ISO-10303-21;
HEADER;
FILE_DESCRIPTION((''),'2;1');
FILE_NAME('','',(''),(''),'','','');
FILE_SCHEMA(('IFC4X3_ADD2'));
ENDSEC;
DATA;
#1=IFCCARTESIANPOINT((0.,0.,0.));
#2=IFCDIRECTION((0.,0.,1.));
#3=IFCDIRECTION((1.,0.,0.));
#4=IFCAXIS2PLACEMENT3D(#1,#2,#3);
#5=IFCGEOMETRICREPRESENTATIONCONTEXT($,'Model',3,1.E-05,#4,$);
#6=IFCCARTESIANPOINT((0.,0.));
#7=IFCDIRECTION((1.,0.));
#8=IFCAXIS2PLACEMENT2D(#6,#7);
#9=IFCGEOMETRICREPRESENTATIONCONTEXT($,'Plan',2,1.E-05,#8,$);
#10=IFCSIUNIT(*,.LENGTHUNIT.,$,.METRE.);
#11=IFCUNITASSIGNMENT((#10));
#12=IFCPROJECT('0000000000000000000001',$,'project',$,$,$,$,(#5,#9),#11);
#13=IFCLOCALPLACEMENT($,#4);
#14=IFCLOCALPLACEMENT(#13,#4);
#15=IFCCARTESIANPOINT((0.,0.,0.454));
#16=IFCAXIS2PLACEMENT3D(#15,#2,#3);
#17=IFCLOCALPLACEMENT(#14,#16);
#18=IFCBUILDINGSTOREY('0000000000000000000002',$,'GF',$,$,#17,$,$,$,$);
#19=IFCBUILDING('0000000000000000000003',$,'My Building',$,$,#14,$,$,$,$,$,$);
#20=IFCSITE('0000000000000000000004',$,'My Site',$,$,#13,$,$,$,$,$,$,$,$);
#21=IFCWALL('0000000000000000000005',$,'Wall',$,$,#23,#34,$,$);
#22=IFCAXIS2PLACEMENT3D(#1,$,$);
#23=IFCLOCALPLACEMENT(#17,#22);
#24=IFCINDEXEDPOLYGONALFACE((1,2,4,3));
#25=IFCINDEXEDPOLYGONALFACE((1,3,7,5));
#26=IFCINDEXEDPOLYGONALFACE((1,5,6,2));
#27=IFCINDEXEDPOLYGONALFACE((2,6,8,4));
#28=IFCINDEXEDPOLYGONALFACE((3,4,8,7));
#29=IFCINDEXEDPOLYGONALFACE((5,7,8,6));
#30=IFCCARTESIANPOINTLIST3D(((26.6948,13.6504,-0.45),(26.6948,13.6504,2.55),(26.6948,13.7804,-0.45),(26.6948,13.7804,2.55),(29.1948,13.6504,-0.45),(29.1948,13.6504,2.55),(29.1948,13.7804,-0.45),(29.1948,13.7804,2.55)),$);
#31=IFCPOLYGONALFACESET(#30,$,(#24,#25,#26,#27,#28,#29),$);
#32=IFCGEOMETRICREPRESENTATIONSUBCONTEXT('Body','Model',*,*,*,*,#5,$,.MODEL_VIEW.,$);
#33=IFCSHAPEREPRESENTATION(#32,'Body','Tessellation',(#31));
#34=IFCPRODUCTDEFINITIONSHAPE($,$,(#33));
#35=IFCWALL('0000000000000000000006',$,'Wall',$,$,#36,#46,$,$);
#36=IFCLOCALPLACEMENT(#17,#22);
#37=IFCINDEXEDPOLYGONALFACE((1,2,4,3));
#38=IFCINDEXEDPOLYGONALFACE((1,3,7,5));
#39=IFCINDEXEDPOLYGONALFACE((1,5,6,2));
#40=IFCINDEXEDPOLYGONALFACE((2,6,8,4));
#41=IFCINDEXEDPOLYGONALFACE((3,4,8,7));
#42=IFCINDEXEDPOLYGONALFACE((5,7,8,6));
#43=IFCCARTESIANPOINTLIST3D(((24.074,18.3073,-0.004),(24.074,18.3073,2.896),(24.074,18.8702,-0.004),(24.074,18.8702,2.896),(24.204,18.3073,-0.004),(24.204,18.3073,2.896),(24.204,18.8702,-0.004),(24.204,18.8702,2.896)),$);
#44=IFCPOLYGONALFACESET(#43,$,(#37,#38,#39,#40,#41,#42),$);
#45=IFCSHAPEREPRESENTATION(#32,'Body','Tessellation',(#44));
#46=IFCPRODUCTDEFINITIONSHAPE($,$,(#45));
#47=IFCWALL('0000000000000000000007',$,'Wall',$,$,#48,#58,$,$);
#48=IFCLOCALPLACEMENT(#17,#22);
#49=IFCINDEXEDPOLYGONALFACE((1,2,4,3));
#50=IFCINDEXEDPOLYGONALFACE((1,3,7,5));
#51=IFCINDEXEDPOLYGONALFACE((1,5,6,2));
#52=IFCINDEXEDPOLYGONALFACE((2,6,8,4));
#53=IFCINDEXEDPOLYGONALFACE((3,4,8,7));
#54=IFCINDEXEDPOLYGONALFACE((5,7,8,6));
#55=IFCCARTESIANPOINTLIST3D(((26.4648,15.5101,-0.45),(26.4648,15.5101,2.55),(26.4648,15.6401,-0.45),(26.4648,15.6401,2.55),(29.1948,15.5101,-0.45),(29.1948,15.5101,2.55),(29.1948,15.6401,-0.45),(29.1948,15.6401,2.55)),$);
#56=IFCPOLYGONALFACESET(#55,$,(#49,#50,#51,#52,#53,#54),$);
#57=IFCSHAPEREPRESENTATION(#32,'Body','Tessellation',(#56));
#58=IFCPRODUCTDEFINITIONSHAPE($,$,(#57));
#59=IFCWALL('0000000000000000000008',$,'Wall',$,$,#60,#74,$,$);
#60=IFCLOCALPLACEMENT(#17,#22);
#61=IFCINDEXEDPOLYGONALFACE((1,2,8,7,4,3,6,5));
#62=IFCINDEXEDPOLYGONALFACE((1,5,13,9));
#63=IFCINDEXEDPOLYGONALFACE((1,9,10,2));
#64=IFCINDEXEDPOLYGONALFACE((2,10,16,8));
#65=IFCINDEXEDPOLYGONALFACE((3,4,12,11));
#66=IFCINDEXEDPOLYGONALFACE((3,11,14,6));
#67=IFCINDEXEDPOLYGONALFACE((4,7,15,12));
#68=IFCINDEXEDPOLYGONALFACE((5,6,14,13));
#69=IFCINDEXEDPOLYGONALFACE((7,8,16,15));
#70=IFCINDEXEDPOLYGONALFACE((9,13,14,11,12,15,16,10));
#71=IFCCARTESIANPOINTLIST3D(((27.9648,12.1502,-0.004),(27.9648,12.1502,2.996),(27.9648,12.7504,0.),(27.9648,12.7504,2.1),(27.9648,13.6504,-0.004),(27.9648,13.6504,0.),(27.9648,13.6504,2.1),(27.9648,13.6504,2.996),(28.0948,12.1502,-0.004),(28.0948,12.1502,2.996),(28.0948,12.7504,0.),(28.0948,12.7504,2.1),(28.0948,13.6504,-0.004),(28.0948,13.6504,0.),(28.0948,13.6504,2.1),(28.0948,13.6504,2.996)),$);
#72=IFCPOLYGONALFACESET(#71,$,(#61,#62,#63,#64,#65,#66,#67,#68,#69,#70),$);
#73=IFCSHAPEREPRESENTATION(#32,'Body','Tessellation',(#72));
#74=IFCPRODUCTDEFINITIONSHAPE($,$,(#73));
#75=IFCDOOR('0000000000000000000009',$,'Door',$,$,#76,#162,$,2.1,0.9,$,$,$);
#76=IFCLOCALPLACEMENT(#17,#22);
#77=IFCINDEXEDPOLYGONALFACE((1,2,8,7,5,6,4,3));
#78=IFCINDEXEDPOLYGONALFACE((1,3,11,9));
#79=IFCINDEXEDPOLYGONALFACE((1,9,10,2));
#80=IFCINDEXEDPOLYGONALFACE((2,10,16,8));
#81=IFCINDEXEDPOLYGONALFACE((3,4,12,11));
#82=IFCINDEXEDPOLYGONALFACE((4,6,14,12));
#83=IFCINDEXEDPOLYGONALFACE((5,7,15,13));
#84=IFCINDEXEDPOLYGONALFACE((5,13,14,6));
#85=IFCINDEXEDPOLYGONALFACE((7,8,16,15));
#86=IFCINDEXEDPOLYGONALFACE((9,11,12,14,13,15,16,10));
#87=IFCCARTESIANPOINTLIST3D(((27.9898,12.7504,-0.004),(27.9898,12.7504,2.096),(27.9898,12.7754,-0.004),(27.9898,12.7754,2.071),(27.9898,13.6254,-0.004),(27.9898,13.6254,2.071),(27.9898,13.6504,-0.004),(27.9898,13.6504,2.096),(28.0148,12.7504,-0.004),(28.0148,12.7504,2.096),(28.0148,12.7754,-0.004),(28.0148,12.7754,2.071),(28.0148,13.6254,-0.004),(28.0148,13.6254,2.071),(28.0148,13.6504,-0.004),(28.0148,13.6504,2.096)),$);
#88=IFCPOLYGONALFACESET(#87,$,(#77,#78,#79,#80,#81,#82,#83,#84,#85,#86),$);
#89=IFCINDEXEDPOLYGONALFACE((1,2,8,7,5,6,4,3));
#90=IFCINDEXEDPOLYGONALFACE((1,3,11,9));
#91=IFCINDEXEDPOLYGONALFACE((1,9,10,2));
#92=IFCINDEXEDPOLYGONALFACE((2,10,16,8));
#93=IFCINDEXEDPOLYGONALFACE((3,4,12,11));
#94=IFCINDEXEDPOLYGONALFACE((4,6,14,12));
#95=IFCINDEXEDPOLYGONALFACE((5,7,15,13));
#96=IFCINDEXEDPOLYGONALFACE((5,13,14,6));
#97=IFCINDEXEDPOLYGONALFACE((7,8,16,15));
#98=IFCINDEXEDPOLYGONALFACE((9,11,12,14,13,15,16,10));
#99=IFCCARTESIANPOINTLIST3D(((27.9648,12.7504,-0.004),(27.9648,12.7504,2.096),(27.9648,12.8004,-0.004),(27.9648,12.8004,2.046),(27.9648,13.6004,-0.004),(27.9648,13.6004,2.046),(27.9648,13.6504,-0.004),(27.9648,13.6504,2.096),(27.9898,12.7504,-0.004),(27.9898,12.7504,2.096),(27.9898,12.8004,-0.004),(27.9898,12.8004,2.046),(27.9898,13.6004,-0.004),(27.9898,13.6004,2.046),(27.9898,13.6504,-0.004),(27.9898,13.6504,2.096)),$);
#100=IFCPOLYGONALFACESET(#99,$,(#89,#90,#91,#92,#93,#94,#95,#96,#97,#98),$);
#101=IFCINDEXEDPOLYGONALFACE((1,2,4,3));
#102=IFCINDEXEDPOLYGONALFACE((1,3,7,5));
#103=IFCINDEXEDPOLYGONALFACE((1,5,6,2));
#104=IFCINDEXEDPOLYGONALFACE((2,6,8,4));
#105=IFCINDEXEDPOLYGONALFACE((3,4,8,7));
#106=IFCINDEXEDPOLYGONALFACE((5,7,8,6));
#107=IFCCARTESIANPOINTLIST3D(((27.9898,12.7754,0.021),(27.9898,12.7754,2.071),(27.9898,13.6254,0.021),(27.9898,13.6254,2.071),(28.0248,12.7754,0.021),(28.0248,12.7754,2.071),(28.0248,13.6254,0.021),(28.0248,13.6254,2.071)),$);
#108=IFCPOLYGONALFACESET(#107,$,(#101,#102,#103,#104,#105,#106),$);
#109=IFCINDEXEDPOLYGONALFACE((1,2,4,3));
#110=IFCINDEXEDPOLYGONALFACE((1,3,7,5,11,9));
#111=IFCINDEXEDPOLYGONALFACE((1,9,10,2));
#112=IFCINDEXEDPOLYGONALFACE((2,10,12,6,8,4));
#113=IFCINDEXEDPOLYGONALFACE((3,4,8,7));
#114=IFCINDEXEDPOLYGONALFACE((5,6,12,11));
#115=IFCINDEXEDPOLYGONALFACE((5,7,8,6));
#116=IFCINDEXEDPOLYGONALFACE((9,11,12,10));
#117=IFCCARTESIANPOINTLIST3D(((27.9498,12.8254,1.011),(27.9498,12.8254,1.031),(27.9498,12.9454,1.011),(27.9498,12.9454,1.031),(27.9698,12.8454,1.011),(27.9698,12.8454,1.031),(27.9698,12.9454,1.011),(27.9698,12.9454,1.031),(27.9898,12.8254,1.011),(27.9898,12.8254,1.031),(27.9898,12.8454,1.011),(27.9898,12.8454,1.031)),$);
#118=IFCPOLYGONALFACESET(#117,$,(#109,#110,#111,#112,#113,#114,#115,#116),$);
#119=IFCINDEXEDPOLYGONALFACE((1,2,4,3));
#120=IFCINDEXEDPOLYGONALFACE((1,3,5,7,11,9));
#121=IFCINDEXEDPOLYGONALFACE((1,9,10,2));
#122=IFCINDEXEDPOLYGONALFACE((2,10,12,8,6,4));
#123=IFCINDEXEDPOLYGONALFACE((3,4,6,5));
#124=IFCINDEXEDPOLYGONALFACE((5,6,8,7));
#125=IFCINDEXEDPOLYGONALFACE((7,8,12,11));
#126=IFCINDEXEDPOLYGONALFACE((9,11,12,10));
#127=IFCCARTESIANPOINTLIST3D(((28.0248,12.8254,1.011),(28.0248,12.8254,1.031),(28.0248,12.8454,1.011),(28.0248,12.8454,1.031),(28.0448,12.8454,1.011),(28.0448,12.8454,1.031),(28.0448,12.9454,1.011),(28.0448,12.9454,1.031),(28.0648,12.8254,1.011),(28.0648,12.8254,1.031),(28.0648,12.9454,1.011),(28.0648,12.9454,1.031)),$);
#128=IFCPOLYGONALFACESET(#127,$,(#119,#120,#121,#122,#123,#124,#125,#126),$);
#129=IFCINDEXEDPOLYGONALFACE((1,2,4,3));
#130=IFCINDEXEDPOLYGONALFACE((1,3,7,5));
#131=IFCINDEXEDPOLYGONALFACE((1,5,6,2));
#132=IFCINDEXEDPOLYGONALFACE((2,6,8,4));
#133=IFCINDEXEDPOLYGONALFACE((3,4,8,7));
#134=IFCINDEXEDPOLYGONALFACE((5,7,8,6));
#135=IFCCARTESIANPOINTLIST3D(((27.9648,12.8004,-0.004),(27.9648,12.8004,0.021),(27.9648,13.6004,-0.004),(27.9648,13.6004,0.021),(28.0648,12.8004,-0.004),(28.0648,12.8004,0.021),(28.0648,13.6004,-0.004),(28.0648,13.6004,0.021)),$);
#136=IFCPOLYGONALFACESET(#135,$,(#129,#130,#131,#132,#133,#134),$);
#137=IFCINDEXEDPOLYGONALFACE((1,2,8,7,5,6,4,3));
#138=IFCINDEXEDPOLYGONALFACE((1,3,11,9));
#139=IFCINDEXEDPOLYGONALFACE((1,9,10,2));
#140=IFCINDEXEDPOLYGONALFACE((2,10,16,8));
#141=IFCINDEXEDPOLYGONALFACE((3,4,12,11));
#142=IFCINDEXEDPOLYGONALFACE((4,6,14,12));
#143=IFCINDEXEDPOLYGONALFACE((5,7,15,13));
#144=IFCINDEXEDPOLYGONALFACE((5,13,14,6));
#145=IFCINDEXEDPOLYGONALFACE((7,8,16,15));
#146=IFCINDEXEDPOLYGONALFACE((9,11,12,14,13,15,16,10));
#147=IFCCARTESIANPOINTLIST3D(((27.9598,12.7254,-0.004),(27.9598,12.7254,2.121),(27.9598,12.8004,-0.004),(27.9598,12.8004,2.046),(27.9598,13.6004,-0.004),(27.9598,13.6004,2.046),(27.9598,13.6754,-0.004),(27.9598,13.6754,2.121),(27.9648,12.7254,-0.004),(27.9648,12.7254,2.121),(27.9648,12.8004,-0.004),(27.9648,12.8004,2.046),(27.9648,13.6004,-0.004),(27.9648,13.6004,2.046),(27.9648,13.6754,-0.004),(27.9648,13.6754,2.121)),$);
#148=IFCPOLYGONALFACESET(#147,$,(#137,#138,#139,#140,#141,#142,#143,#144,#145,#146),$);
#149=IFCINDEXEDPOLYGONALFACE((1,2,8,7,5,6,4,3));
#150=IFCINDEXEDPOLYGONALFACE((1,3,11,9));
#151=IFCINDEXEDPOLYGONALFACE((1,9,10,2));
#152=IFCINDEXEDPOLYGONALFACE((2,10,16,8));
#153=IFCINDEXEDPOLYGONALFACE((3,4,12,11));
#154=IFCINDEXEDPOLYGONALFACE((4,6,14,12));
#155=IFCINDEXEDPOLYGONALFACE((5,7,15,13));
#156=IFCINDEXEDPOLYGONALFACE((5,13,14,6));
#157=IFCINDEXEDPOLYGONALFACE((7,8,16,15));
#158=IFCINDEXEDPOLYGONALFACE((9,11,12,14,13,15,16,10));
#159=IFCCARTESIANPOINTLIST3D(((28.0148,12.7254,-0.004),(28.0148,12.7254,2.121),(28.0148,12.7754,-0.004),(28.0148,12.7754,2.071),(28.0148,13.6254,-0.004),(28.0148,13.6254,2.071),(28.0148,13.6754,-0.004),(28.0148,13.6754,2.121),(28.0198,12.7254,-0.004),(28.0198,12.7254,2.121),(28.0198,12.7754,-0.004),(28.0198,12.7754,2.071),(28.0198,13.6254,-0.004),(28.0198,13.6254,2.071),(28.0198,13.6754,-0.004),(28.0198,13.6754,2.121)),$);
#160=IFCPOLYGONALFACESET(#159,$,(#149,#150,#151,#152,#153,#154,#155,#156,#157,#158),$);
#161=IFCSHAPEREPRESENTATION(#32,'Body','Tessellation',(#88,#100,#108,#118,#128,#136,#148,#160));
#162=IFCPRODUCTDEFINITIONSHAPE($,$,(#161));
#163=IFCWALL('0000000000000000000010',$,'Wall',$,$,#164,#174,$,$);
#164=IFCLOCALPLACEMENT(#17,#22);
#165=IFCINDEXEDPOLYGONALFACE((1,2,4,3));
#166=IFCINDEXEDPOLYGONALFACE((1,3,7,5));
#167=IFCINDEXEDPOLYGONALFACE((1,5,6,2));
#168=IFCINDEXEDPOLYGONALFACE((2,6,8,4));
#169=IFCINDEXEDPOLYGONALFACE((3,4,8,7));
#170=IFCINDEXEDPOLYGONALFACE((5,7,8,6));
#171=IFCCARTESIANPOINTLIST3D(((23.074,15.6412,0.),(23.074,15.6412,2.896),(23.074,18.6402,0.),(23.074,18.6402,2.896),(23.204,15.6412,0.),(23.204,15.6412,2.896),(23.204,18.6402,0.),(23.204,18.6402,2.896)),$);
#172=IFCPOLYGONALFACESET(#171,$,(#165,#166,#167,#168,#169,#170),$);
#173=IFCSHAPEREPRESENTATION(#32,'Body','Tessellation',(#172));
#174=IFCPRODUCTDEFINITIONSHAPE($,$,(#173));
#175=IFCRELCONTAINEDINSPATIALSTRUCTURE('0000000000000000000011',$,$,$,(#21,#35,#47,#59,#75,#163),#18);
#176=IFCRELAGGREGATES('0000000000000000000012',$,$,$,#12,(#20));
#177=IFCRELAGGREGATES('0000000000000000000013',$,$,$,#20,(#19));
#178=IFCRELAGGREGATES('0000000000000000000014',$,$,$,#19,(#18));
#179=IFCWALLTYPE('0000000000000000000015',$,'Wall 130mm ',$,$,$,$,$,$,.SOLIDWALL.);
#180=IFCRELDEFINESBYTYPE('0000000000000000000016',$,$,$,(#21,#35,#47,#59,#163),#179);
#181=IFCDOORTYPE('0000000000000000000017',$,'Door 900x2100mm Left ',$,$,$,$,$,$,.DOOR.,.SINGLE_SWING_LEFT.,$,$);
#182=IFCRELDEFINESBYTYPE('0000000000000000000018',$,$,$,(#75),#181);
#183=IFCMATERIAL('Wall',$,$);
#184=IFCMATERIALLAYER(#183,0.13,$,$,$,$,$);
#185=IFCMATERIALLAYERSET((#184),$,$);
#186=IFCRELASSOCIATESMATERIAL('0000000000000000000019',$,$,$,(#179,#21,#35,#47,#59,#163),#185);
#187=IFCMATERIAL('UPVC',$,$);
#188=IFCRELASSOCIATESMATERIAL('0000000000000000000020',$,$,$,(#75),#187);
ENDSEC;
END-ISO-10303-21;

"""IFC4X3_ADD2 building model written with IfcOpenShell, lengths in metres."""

from ifc_helpers import new_model, entity, si_unit, frame, origin_with_axes, origin_2d_with_axis, place, context, subcontext, project, spatial, line, indexed_curve, outline, extrude, clip, halfspace, shape, source, transform, mapped, material, layer, layer_set, layer_usage, type_object, type_shapes, element, fill, save


model = new_model("IFC4X3_ADD2")

# Units and contexts
model_context = context("Model", 3, precision=1e-05, world=origin_with_axes())
plan_context = context("Plan", 2, precision=1e-05, world=origin_2d_with_axis())
body_context_1 = subcontext(model_context, "Body", "Model", "MODEL_VIEW")
body_context_2 = subcontext(plan_context, "Body", "Plan", "PLAN_VIEW")
ifc_project = project(units=[si_unit("LENGTHUNIT", "METRE")], contexts=[model_context, plan_context])

# Site, building, storey
site_placement = place(None, origin_with_axes())
site = spatial("IfcSite", under=ifc_project, at=site_placement, Name="My Site")
building_placement = place(site_placement, origin_with_axes())
building = spatial("IfcBuilding", under=site, at=building_placement, Name="My Building")
storey_placement = place(building_placement, frame((0.0, 0.0, 0.454), z_axis=(0.0, 0.0, 1.0), x_axis=(1.0, 0.0, 0.0)))
storey = spatial("IfcBuildingStorey", under=building, at=storey_placement, Name="GF")

# Walls
ifc_material_1 = material(Name="Wall")
ifc_layer_1 = layer(ifc_material_1, 0.13)
ifc_layer_set_1 = layer_set([ifc_layer_1])
ifc_layer_usage_1 = layer_usage(ifc_layer_set_1, "AXIS2", "POSITIVE", 0.0)
wall_type_1 = type_object("IfcWallType", Name="Wall 130mm ", PredefinedType="SOLIDWALL", material=ifc_layer_set_1)
wall_1_placement = place(storey_placement, frame((29.1948, 13.7804, -0.45), z_axis=(0.0, 0.0, 1.0), x_axis=(-1.0, 0.0, 0.0)))
element("IfcWall", 1, at=wall_1_placement, inside=storey, type_object=wall_type_1, material=ifc_layer_usage_1, Name="Wall", context=body_context_1, shape_type="SweptSolid", body=[
    extrude(outline(indexed_curve([(0.0, 0.0), (0.0, 0.13), (2.5, 0.13), (2.5, 0.0), (0.0, 0.0)], self_intersect=False)), origin_with_axes(), (0.0, 0.0, 1.0), 3.0),
])
ifc_layer_usage_2 = layer_usage(ifc_layer_set_1, "AXIS2", "POSITIVE", 0.0)
wall_2_placement = place(storey_placement, frame((24.204, 18.3073, -0.004), z_axis=(0.0, 0.0, 1.0), x_axis=(0.000001, 1.0, 0.0)))
element("IfcWall", 2, at=wall_2_placement, inside=storey, type_object=wall_type_1, material=ifc_layer_usage_2, Name="Wall", context=body_context_1, shape_type="SweptSolid", body=[
    extrude(outline(indexed_curve([(0.0, 0.0), (0.0, 0.13), (0.5629, 0.13), (0.5629, 0.0), (0.0, 0.0)], self_intersect=False)), origin_with_axes(), (0.0, 0.0, 1.0), 2.9),
])
ifc_layer_usage_3 = layer_usage(ifc_layer_set_1, "AXIS2", "POSITIVE", 0.0)
wall_3_placement = place(storey_placement, frame((29.1948, 15.6401, -0.45), z_axis=(0.0, 0.0, 1.0), x_axis=(-1.0, 0.0, 0.0)))
element("IfcWall", 3, at=wall_3_placement, inside=storey, type_object=wall_type_1, material=ifc_layer_usage_3, Name="Wall", context=body_context_1, shape_type="SweptSolid", body=[
    extrude(outline(indexed_curve([(0.0, 0.0), (0.0, 0.13), (2.73, 0.13), (2.73, 0.0), (0.0, 0.0)], self_intersect=False)), origin_with_axes(), (0.0, 0.0, 1.0), 3.0),
])

# Wall, opening, door
ifc_layer_usage_4 = layer_usage(ifc_layer_set_1, "AXIS2", "POSITIVE", 0.0)
wall_4_placement = place(storey_placement, frame((27.9648, 13.6504, -0.004), z_axis=(0.0, 0.0, 1.0), x_axis=(0.0, -1.0, 0.0)))
wall_4 = element("IfcWall", 4, at=wall_4_placement, inside=storey, type_object=wall_type_1, material=ifc_layer_usage_4, Name="Wall", context=body_context_1, shape_type="SweptSolid", body=[
    extrude(outline(indexed_curve([(0.0, 0.0), (0.0, 0.13), (1.5002, 0.13), (1.5002, 0.0), (0.0, 0.0)], self_intersect=False)), origin_with_axes(), (0.0, 0.0, 1.0), 3.0),
])
shared_shape_1 = source(origin_with_axes(), body_context_1, "Body", "SweptSolid", [
    extrude(outline(indexed_curve([(0.0, 0.0), (0.9, 0.0), (0.9, 2.1), (0.0, 2.1)], segments=[line(1, 2, 3, 4, 1)])), frame((0.0, -0.6, 0.0), z_axis=(0.0, -1.0, 0.0), x_axis=(1.0, 0.0, 0.0)), (0.0, 0.0, -1.0), 1.2),
])
opening_1_placement = place(wall_4_placement, frame((0.0, 0.0, 0.004), z_axis=(0.0, 0.0, 1.0), x_axis=(1.0, 0.0, 0.0)))
opening_1 = element("IfcOpeningElement", 5, at=opening_1_placement, cuts=wall_4, PredefinedType="OPENING", context=body_context_1, shape_type="MappedRepresentation", body=[
    mapped(shared_shape_1, transform((0.0, 0.0, 0.0), x_axis=(1.0, 0.0, 0.0), y_axis=(0.0, 1.0, 0.0), z_axis=(0.0, 0.0, 1.0), scale=1.0)),
])
ifc_material_2 = material(Name="UPVC")
door_type_1 = type_object("IfcDoorType", Name="Door 900x2100mm Left ", OperationType="SINGLE_SWING_LEFT", PredefinedType="DOOR")
shared_shape_2 = source(origin_with_axes(), body_context_1, "Body", "SweptSolid", [
    extrude(outline(indexed_curve([(0.0, 0.0), (0.0, 2.1), (0.9, 2.1), (0.9, 0.0), (0.875, 0.0), (0.875, 2.075), (0.025, 2.075), (0.025, 0.0)], segments=[line(1, 2, 3, 4, 5, 6, 7, 8, 1)])), frame((0.0, 0.025, 0.0), z_axis=(0.0, -1.0, 0.0), x_axis=(1.0, 0.0, 0.0)), (0.0, 0.0, -1.0), 0.025),
    extrude(outline(indexed_curve([(0.0, 0.0), (0.0, 2.1), (0.9, 2.1), (0.9, 0.0), (0.85, 0.0), (0.85, 2.05), (0.05, 2.05), (0.05, 0.0)], segments=[line(1, 2, 3, 4, 5, 6, 7, 8, 1)])), frame((0.0, 0.0, 0.0), z_axis=(0.0, -1.0, 0.0), x_axis=(1.0, 0.0, 0.0)), (0.0, 0.0, -1.0), 0.025),
    extrude(outline(indexed_curve([(0.0, 0.0), (0.85, 0.0), (0.85, 0.035), (0.0, 0.035)], segments=[line(1, 2, 3, 4, 1)])), frame((0.025, 0.025, 0.025), z_axis=(0.0, 0.0, 1.0), x_axis=(1.0, 0.0, 0.0)), (0.0, 0.0, 1.0), 2.05),
    extrude(outline(indexed_curve([(0.0, 0.0), (0.0, -0.04), (-0.12, -0.04), (-0.12, -0.02), (-0.02, -0.02), (-0.02, 0.0)], segments=[line(1, 2, 3, 4, 5, 6, 1)])), frame((0.825, 0.025, 1.015), z_axis=(0.0, 0.0, 1.0), x_axis=(1.0, 0.0, 0.0)), (0.0, 0.0, 1.0), 0.02),
    extrude(outline(indexed_curve([(0.0, 0.0), (0.0, 0.04), (-0.12, 0.04), (-0.12, 0.02), (-0.02, 0.02), (-0.02, 0.0)], segments=[line(1, 2, 3, 4, 5, 6, 1)])), frame((0.825, 0.06, 1.015), z_axis=(0.0, 0.0, 1.0), x_axis=(1.0, 0.0, 0.0)), (0.0, 0.0, 1.0), 0.02),
    extrude(outline(indexed_curve([(0.0, 0.0), (0.8, 0.0), (0.8, 0.1), (0.0, 0.1)], segments=[line(1, 2, 3, 4, 1)])), frame((0.05, 0.0, 0.0), z_axis=(0.0, 0.0, 1.0), x_axis=(1.0, 0.0, 0.0)), (0.0, 0.0, 1.0), 0.025),
    extrude(outline(indexed_curve([(0.0, 0.0), (0.0, 2.125), (0.95, 2.125), (0.95, 0.0), (0.875, 0.0), (0.875, 2.05), (0.075, 2.05), (0.075, 0.0)], segments=[line(1, 2, 3, 4, 5, 6, 7, 8, 1)])), frame((-0.025, -0.005, 0.0), z_axis=(0.0, -1.0, 0.0), x_axis=(1.0, 0.0, 0.0)), (0.0, 0.0, -1.0), 0.005),
    extrude(outline(indexed_curve([(0.0, 0.0), (0.0, 2.125), (0.95, 2.125), (0.95, 0.0), (0.9, 0.0), (0.9, 2.075), (0.05, 2.075), (0.05, 0.0)], segments=[line(1, 2, 3, 4, 5, 6, 7, 8, 1)])), frame((-0.025, 0.05, 0.0), z_axis=(0.0, -1.0, 0.0), x_axis=(1.0, 0.0, 0.0)), (0.0, 0.0, -1.0), 0.005),
])
shared_shape_3 = source(origin_with_axes(), body_context_2, "Body", "Curve2D", [
    entity("IfcIndexedPolyCurve", entity("IfcCartesianPointList2D", [[0.0, 0.0], [0.0, 0.05], [0.025, 0.05], [0.025, 0.025], [0.05, 0.025], [0.05, 0.0]]), [entity("IfcLineIndex", [1, 2, 3, 4, 5, 6, 1])]),
    entity("IfcIndexedPolyCurve", entity("IfcCartesianPointList2D", [[0.9, 0.0], [0.9, 0.05], [0.875, 0.05], [0.875, 0.025], [0.85, 0.025], [0.85, 0.0]]), [entity("IfcLineIndex", [1, 2, 3, 4, 5, 6, 1])]),
    entity("IfcTrimmedCurve", entity("IfcEllipse", entity("IfcAxis2Placement2D", entity("IfcCartesianPoint", [0.06, 0.05]), entity("IfcDirection", [1.0, 0.0])), 0.815, 0.85), [entity("IfcCartesianPoint", [0.875, 0.05])], [entity("IfcCartesianPoint", [0.06, 0.9])], True, "CARTESIAN"),
    entity("IfcIndexedPolyCurve", entity("IfcCartesianPointList2D", [[0.025, 0.05], [0.06, 0.05], [0.06, 0.9], [0.025, 0.9]]), [entity("IfcLineIndex", [1, 2, 3, 4, 1])]),
])
type_shapes(door_type_1, [shared_shape_2, shared_shape_3])
door_1_placement = place(opening_1_placement, frame((0.0, 0.0, -0.004), z_axis=(0.0, 0.0, 1.0), x_axis=(1.0, 0.0, 0.0)))
door_1 = element("IfcDoor", 6, at=door_1_placement, inside=storey, type_object=door_type_1, material=ifc_material_2, Name="Door", OverallHeight=2.1, OverallWidth=0.9, shapes=[
    shape(body_context_1, "Body", "MappedRepresentation", [mapped(shared_shape_2, transform((0.0, 0.0, 0.0), x_axis=(1.0, 0.0, 0.0), y_axis=(0.0, 1.0, 0.0), z_axis=(0.0, 0.0, 1.0), scale=1.0))]),
    shape(body_context_2, "Body", "MappedRepresentation", [mapped(shared_shape_3, transform((0.0, 0.0, 0.0), x_axis=(1.0, 0.0, 0.0), y_axis=(0.0, 1.0, 0.0), z_axis=(0.0, 0.0, 1.0), scale=1.0))]),
])
fill(opening_1, door_1)

# Wall
ifc_layer_usage_5 = layer_usage(ifc_layer_set_1, "AXIS2", "POSITIVE", 0.0)
wall_5_placement = place(storey_placement, frame((23.204, 15.6412, 0.0), z_axis=(0.0, 0.0, 1.0), x_axis=(0.000001, 1.0, 0.0)))
element("IfcWall", 7, at=wall_5_placement, inside=storey, type_object=wall_type_1, material=ifc_layer_usage_5, Name="Wall", context=body_context_1, shape_type="Clipping", body=[
    clip(extrude(outline(indexed_curve([(0.0, 0.0), (0.0, 0.13), (2.999, 0.13), (2.999, 0.0), (0.0, 0.0)], self_intersect=False)), origin_with_axes(), (0.0, 0.0, 1.0), 3.35), halfspace(frame((0.0, 0.0, 2.896), z_axis=(0.0, 0.0, 1.0), x_axis=(-1.0, 0.0, 0.0)), False)),
])

save(model, "model.ifc")
